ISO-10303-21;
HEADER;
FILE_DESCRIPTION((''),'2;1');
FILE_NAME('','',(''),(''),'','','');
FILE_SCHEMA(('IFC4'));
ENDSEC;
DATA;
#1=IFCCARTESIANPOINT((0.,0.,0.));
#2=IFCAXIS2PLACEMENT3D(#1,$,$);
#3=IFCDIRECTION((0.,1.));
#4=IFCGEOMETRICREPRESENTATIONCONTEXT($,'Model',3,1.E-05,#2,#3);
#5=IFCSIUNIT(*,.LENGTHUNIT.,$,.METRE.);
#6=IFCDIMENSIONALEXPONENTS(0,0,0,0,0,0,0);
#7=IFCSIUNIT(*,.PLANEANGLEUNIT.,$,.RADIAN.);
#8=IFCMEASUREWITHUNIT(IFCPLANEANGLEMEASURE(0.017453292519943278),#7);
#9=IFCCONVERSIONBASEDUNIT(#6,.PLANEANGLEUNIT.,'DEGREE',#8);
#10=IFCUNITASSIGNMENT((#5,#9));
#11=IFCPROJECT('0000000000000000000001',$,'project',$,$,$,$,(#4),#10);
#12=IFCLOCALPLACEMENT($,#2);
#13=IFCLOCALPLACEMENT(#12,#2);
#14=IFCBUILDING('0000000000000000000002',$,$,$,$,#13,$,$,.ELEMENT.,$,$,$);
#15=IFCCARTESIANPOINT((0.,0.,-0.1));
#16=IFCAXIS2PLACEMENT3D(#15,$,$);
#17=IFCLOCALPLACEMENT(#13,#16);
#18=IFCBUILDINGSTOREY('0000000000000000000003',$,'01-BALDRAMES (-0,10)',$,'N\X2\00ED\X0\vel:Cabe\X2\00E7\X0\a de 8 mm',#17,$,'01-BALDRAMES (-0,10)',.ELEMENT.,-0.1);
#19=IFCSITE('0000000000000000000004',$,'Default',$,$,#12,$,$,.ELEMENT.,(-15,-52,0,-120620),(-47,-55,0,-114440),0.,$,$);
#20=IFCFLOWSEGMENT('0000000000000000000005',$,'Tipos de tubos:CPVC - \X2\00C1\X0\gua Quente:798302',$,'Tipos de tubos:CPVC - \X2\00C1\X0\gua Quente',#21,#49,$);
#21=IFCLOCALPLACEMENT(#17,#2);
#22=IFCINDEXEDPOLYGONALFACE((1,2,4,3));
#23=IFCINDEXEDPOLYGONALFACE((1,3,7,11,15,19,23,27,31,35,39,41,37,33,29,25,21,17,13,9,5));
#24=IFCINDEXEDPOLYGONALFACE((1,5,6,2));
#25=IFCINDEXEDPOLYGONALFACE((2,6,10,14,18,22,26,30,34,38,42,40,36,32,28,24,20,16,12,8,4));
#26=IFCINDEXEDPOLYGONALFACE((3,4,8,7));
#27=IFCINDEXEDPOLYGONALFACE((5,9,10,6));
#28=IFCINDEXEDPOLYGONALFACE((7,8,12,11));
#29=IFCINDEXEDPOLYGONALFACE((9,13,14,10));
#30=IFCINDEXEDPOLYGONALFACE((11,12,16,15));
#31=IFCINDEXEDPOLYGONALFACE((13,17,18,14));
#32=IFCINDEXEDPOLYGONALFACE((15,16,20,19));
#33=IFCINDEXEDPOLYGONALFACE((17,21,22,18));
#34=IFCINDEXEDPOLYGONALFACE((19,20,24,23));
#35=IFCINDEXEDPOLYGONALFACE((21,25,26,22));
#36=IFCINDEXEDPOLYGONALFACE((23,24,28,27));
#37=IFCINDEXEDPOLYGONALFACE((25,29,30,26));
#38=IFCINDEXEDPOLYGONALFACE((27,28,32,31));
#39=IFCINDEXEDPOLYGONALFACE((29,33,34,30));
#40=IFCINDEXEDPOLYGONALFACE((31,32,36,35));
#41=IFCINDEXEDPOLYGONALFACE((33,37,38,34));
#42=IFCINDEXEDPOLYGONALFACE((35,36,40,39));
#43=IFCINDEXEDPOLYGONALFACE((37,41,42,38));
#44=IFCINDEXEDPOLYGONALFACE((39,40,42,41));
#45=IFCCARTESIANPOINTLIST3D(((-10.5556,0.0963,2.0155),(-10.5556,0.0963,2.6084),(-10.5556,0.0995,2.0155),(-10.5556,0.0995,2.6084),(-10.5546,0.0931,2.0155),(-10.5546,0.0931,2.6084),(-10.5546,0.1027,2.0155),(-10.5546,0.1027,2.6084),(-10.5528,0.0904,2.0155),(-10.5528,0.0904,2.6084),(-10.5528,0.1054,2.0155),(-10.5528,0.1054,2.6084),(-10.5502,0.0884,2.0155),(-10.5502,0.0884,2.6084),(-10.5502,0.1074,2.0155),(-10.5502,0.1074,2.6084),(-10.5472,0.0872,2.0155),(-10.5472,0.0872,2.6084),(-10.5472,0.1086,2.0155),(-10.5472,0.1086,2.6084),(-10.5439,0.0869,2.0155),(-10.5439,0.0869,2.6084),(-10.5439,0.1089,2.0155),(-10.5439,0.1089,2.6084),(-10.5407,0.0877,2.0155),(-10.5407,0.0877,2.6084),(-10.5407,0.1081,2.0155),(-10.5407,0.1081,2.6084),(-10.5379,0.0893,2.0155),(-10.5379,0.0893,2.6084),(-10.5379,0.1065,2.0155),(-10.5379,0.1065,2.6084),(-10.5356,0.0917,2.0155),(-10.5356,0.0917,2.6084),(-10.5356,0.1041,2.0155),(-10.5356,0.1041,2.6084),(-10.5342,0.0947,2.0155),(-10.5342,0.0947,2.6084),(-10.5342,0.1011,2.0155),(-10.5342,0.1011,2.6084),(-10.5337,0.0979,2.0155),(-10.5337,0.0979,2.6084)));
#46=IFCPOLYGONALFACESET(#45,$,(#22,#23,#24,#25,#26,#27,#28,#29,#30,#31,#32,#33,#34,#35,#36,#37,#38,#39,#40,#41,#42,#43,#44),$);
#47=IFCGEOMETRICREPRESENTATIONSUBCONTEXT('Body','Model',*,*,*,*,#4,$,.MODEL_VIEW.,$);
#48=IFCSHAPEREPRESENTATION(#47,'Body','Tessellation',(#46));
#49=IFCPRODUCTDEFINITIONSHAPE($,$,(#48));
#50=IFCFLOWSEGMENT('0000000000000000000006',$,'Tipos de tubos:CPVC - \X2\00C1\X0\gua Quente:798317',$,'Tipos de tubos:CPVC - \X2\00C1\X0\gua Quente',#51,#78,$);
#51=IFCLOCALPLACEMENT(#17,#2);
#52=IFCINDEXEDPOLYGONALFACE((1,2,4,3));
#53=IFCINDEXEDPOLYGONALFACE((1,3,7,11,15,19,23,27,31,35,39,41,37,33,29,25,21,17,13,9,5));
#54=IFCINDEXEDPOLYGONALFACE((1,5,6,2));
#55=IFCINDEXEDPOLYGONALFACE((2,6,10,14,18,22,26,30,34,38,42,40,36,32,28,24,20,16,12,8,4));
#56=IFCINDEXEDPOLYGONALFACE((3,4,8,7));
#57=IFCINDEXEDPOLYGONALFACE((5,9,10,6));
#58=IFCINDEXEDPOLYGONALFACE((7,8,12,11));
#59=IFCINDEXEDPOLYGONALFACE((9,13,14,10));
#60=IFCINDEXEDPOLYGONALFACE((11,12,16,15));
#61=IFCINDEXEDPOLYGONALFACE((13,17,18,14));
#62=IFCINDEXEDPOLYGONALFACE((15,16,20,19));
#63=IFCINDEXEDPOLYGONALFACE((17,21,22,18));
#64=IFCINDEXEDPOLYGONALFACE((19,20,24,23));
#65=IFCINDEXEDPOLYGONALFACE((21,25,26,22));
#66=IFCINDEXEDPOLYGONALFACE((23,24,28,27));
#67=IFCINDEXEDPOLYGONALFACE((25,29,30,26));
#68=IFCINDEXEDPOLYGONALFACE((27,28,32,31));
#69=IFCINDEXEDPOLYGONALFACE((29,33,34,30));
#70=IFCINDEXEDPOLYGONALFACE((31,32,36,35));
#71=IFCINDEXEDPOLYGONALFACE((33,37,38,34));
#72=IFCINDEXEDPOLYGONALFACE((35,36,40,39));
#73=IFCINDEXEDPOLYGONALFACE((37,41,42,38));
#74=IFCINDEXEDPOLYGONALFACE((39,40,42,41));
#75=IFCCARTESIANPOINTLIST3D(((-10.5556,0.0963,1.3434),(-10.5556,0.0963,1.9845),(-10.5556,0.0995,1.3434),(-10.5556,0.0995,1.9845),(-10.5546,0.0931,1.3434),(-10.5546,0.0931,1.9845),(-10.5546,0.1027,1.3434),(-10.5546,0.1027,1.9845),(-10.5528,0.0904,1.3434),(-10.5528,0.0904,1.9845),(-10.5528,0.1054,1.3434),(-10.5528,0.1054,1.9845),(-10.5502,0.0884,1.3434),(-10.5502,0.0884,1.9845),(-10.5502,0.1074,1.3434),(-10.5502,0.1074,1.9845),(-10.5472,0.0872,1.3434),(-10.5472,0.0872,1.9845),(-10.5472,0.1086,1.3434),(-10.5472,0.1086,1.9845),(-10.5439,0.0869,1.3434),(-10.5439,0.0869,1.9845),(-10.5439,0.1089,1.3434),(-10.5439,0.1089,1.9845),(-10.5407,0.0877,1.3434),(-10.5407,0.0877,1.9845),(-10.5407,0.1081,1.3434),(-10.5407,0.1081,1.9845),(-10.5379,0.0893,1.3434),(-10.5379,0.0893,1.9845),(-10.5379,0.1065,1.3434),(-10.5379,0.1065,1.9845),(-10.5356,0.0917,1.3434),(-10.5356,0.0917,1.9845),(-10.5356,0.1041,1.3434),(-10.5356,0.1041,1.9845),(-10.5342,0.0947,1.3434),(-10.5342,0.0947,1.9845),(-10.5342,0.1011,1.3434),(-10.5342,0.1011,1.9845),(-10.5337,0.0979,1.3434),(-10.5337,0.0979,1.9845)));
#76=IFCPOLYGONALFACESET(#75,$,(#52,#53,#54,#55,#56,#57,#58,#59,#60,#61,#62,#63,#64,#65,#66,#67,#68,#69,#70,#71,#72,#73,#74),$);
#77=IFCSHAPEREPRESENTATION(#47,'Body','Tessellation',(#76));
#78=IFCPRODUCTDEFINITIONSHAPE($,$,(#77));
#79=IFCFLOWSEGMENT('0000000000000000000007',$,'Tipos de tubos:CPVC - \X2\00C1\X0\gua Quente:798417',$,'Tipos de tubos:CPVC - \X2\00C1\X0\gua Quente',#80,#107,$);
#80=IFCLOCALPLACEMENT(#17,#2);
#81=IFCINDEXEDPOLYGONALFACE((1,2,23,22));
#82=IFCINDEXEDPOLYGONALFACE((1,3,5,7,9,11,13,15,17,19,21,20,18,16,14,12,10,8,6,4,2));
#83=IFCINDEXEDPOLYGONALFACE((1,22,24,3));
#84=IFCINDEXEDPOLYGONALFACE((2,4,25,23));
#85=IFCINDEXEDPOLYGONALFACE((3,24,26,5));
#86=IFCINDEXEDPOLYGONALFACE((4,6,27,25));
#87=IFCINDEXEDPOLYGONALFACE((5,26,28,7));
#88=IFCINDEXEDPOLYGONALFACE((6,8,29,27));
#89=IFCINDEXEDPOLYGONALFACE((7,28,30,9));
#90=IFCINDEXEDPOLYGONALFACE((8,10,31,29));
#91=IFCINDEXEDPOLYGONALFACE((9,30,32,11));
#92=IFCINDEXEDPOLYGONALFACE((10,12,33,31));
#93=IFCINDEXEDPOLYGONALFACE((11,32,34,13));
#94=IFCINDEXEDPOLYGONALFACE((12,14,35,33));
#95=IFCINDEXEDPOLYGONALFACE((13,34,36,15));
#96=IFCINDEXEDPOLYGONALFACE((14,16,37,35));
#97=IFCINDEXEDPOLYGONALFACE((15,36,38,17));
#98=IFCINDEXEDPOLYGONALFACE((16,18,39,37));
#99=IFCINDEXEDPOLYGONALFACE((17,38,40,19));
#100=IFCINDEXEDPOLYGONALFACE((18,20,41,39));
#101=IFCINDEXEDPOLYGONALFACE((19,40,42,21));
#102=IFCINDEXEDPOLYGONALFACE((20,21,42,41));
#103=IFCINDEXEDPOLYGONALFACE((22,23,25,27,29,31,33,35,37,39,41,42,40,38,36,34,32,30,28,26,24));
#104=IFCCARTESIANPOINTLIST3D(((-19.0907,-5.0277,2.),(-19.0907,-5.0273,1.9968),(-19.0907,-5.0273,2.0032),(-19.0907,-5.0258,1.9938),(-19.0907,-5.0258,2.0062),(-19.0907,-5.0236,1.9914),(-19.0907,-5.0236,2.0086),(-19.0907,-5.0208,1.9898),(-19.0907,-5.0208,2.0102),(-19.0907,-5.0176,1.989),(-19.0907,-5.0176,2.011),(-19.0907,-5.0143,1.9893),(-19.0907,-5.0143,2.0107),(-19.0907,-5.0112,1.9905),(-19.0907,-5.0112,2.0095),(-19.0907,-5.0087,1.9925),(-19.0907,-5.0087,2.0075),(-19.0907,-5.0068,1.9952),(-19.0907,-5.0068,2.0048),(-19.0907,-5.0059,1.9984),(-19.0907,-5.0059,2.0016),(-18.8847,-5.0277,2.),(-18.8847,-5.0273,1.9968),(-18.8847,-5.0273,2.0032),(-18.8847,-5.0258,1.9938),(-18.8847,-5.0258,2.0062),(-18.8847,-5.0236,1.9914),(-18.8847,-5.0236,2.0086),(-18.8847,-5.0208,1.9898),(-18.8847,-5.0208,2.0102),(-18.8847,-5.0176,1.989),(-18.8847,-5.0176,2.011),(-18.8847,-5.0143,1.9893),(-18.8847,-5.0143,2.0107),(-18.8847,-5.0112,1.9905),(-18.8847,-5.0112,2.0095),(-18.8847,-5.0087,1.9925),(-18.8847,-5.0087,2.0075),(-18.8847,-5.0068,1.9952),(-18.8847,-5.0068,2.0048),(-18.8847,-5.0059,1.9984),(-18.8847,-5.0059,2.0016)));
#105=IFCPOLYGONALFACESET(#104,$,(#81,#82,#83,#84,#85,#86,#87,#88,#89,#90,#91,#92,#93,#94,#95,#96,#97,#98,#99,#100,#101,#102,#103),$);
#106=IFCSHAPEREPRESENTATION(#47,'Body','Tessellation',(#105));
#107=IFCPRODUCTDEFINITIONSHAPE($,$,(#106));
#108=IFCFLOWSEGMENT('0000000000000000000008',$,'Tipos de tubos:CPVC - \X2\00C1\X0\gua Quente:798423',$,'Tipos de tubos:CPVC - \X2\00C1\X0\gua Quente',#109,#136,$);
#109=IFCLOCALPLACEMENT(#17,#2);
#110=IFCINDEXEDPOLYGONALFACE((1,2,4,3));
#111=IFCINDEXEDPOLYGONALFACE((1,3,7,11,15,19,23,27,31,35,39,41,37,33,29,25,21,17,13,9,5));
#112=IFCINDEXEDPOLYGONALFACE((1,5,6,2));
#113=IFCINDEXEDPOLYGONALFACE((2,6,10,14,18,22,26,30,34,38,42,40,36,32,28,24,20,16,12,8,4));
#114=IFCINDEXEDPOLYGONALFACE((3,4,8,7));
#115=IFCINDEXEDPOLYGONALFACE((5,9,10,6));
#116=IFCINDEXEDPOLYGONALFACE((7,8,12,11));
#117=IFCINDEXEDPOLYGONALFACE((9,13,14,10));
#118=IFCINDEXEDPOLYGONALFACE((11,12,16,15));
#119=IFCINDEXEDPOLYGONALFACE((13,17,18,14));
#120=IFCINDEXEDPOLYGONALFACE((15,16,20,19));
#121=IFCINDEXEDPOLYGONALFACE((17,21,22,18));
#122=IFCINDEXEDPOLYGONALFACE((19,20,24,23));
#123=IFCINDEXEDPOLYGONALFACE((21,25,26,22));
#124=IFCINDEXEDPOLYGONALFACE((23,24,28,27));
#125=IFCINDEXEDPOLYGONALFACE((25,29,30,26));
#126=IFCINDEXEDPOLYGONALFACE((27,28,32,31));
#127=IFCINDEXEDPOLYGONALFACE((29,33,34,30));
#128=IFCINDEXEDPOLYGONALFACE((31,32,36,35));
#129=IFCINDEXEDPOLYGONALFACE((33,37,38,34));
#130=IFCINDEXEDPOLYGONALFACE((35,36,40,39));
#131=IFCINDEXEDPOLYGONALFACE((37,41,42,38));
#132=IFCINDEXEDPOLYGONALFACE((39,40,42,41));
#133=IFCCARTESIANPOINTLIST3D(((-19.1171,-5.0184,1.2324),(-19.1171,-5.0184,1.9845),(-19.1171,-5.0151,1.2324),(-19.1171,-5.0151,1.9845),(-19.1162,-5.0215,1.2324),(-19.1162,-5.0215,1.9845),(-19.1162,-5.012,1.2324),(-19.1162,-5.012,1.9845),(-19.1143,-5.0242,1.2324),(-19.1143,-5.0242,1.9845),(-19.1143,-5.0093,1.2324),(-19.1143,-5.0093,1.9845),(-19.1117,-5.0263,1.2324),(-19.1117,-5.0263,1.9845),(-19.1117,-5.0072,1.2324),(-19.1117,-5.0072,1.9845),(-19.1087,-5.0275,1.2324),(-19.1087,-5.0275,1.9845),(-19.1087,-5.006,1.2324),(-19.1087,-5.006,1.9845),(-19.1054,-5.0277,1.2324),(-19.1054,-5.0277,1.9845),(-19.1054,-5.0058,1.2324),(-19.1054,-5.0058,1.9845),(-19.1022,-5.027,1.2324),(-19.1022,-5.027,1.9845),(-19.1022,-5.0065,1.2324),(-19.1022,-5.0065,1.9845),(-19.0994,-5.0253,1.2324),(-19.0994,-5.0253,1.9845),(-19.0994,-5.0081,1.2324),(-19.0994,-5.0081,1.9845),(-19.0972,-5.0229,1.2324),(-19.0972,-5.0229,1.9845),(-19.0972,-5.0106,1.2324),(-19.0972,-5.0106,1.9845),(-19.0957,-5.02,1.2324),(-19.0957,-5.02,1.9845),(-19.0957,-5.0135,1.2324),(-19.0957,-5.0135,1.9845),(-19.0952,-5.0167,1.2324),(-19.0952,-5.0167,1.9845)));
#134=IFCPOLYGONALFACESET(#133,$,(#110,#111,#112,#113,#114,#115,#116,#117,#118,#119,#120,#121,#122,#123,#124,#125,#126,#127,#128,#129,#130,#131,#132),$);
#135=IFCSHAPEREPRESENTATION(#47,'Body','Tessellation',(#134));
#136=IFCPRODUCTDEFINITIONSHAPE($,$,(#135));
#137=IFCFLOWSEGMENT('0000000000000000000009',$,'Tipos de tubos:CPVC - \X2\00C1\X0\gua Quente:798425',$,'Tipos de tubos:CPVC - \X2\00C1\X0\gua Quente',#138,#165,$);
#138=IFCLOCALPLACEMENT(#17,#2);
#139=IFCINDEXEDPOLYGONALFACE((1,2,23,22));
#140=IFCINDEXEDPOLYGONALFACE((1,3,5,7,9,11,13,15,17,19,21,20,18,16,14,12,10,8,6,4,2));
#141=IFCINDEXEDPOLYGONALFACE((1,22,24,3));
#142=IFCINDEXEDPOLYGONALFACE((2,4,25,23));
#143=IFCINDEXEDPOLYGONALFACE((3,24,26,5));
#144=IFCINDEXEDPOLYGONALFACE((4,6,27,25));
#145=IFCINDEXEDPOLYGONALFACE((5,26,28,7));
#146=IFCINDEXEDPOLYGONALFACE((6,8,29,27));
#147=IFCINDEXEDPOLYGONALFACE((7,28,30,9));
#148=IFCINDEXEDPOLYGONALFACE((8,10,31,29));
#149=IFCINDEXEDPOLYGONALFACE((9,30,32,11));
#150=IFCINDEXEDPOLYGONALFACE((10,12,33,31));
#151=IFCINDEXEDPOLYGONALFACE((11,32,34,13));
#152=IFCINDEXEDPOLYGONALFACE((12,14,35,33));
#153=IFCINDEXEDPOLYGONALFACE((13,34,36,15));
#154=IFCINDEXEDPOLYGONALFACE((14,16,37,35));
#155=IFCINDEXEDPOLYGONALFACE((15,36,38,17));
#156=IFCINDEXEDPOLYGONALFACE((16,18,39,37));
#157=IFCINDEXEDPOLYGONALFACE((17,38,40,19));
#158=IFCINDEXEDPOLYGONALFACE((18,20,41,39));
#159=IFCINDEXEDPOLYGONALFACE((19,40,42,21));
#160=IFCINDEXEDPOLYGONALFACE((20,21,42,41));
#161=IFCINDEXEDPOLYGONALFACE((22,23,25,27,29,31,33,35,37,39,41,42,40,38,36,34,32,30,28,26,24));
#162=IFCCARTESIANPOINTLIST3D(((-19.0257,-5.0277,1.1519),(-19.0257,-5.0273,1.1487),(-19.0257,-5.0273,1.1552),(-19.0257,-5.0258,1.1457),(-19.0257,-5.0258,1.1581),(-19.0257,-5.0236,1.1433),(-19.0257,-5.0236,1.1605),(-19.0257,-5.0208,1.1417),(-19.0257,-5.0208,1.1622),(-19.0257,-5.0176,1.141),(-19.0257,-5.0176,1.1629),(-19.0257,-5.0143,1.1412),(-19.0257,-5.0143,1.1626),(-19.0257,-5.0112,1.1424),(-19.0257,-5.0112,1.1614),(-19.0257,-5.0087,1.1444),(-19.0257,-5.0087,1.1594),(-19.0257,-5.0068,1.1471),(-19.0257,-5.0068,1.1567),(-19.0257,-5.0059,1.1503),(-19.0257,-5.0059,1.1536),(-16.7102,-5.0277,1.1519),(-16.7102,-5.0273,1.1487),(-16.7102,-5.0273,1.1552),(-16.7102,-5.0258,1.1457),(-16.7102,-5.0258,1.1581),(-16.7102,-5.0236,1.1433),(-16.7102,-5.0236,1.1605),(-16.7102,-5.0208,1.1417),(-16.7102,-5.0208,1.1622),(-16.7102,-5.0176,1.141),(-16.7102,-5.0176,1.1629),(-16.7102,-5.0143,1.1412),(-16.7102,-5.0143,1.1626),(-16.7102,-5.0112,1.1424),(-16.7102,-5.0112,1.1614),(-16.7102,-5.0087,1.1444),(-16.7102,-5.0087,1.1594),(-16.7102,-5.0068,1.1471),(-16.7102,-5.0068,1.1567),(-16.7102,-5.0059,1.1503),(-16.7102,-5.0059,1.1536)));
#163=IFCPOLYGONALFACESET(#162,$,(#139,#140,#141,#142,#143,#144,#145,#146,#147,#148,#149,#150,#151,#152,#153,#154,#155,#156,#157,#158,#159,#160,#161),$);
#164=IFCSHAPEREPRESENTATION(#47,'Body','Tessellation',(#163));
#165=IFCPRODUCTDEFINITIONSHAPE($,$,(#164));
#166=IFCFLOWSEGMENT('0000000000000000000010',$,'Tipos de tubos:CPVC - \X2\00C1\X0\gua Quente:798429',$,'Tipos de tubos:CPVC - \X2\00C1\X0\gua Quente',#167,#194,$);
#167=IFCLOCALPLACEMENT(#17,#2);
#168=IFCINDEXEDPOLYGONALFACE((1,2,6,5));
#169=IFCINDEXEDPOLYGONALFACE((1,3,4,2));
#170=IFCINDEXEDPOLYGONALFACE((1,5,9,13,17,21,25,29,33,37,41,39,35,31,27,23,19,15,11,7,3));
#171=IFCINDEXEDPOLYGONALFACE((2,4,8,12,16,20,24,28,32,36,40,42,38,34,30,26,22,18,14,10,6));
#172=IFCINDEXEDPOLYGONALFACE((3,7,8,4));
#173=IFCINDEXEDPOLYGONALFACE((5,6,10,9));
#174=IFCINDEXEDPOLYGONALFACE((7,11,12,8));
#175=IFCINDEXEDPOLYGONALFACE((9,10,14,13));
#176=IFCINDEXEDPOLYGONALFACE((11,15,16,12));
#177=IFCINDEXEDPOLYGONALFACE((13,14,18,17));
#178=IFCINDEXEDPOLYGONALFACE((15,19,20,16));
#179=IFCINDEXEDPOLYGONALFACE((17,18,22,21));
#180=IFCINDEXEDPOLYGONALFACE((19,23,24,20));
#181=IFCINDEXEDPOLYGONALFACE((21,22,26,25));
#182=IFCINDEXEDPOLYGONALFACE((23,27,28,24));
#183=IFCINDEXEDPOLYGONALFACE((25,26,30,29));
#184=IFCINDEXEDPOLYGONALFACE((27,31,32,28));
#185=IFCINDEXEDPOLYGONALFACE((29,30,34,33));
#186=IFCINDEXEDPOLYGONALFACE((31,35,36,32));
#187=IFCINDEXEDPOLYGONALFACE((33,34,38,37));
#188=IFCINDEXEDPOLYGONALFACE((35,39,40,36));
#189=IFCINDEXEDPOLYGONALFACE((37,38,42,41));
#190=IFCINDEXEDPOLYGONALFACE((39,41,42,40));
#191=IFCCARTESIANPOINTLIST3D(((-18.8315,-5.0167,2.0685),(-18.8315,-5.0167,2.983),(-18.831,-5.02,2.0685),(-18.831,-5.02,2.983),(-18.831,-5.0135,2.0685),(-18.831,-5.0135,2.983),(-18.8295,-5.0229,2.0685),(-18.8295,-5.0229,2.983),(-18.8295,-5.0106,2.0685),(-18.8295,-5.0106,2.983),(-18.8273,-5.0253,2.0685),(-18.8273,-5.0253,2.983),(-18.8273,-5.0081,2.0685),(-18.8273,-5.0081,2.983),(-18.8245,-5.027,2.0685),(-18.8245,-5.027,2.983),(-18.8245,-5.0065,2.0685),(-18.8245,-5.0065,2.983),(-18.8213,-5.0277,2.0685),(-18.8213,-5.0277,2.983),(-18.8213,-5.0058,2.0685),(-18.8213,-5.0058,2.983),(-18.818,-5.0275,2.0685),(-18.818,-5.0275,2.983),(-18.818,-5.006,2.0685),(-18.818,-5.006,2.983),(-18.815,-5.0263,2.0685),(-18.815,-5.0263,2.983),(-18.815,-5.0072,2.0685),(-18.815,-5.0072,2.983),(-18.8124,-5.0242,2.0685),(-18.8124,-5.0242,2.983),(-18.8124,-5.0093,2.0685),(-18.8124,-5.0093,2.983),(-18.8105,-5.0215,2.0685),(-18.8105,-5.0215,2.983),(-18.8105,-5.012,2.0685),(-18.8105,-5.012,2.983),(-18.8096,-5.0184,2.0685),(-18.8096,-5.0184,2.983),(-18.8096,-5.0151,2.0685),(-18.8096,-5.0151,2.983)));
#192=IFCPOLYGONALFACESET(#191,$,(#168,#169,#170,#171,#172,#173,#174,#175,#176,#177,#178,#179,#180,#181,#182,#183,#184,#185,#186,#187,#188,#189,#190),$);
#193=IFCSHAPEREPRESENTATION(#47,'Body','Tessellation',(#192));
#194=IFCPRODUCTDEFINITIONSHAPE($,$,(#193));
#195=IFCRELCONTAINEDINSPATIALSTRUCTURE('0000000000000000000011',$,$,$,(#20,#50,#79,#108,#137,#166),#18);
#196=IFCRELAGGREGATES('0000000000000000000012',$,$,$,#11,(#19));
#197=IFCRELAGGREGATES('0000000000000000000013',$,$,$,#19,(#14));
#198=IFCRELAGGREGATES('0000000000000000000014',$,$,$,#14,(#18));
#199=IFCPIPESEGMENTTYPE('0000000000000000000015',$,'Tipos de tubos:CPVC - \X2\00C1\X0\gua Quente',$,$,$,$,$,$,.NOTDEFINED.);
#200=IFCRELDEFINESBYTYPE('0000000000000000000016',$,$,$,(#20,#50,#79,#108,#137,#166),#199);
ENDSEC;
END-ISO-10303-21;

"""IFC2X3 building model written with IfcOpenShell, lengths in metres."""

from ifc_helpers import new_model, entity, si_unit, converted_unit, direction, frame, origin, origin_2d_with_axis, place, context, subcontext, project, spatial, circle, extrude, type_object, element, save


model = new_model("IFC2X3")

# Units and contexts
model_context = context("Model", 3, precision=1e-05, world=origin(), true_north=direction((0.0, 1.0)))
body_context = subcontext(model_context, "Body", "Model", "MODEL_VIEW")
ifc_project = project(units=[si_unit("LENGTHUNIT", "METRE"), converted_unit("PLANEANGLEUNIT", "DEGREE", entity("IfcPlaneAngleMeasure", 0.017453292519943278), si_unit("PLANEANGLEUNIT", "RADIAN"), dimensions=[0, 0, 0, 0, 0, 0, 0])], contexts=[model_context])

# Site, building, storey
site_placement = place(None, origin())
site = spatial("IfcSite", under=ifc_project, at=site_placement, Name="Default", CompositionType="ELEMENT", RefLatitude=(-15, -52, 0, -120620), RefLongitude=(-47, -55, 0, -114440), RefElevation=0.0)
building_placement = place(site_placement, origin())
building = spatial("IfcBuilding", under=site, at=building_placement, CompositionType="ELEMENT")
storey_placement = place(building_placement, frame((0.0, 0.0, -0.1)))
storey = spatial("IfcBuildingStorey", under=building, at=storey_placement, Name="01-BALDRAMES (-0,10)", ObjectType="Nível:Cabeça de 8 mm", LongName="01-BALDRAMES (-0,10)", CompositionType="ELEMENT", Elevation=-0.1)

# Flow segments
pipe_segment_type_1 = type_object("IfcPipeSegmentType", Name="Tipos de tubos:CPVC - Água Quente", PredefinedType="NOTDEFINED")
flow_segment_1_placement = place(storey_placement, origin())
element("IfcFlowSegment", 1, at=flow_segment_1_placement, inside=storey, type_object=pipe_segment_type_1, Name="Tipos de tubos:CPVC - Água Quente:798302", ObjectType="Tipos de tubos:CPVC - Água Quente", context=body_context, shape_type="SweptSolid", body=[
    extrude(circle(Radius=0.011, at=origin_2d_with_axis()), frame((-10.5447, 0.0979, 2.0155)), (0.0, 0.0, 1.0), 0.5929),
])
flow_segment_2_placement = place(storey_placement, origin())
element("IfcFlowSegment", 2, at=flow_segment_2_placement, inside=storey, type_object=pipe_segment_type_1, Name="Tipos de tubos:CPVC - Água Quente:798317", ObjectType="Tipos de tubos:CPVC - Água Quente", context=body_context, shape_type="SweptSolid", body=[
    extrude(circle(Radius=0.011, at=origin_2d_with_axis()), frame((-10.5447, 0.0979, 1.3434)), (0.0, 0.0, 1.0), 0.6411),
])
flow_segment_3_placement = place(storey_placement, origin())
element("IfcFlowSegment", 3, at=flow_segment_3_placement, inside=storey, type_object=pipe_segment_type_1, Name="Tipos de tubos:CPVC - Água Quente:798417", ObjectType="Tipos de tubos:CPVC - Água Quente", context=body_context, shape_type="SweptSolid", body=[
    extrude(circle(Radius=0.011, at=origin_2d_with_axis()), frame((-19.0907, -5.0167, 2.0), z_axis=(1.0, 0.0, 0.0), x_axis=(0.0, -1.0, 0.0)), (0.0, 0.0, 1.0), 0.206),
])
flow_segment_4_placement = place(storey_placement, origin())
element("IfcFlowSegment", 4, at=flow_segment_4_placement, inside=storey, type_object=pipe_segment_type_1, Name="Tipos de tubos:CPVC - Água Quente:798423", ObjectType="Tipos de tubos:CPVC - Água Quente", context=body_context, shape_type="SweptSolid", body=[
    extrude(circle(Radius=0.011, at=origin_2d_with_axis()), frame((-19.1062, -5.0167, 1.2324)), (0.0, 0.0, 1.0), 0.7521),
])
flow_segment_5_placement = place(storey_placement, origin())
element("IfcFlowSegment", 5, at=flow_segment_5_placement, inside=storey, type_object=pipe_segment_type_1, Name="Tipos de tubos:CPVC - Água Quente:798425", ObjectType="Tipos de tubos:CPVC - Água Quente", context=body_context, shape_type="SweptSolid", body=[
    extrude(circle(Radius=0.011, at=origin_2d_with_axis()), frame((-19.0257, -5.0167, 1.1519), z_axis=(1.0, 0.0, 0.0), x_axis=(0.0, -1.0, 0.0)), (0.0, 0.0, 1.0), 2.3155),
])
flow_segment_6_placement = place(storey_placement, origin())
element("IfcFlowSegment", 6, at=flow_segment_6_placement, inside=storey, type_object=pipe_segment_type_1, Name="Tipos de tubos:CPVC - Água Quente:798429", ObjectType="Tipos de tubos:CPVC - Água Quente", context=body_context, shape_type="SweptSolid", body=[
    extrude(circle(Radius=0.011, at=origin_2d_with_axis()), frame((-18.8205, -5.0167, 2.0685), z_axis=(0.0, 0.0, 1.0), x_axis=(-1.0, 0.0, 0.0)), (0.0, 0.0, 1.0), 0.9145),
])

save(model, "model.ifc")
